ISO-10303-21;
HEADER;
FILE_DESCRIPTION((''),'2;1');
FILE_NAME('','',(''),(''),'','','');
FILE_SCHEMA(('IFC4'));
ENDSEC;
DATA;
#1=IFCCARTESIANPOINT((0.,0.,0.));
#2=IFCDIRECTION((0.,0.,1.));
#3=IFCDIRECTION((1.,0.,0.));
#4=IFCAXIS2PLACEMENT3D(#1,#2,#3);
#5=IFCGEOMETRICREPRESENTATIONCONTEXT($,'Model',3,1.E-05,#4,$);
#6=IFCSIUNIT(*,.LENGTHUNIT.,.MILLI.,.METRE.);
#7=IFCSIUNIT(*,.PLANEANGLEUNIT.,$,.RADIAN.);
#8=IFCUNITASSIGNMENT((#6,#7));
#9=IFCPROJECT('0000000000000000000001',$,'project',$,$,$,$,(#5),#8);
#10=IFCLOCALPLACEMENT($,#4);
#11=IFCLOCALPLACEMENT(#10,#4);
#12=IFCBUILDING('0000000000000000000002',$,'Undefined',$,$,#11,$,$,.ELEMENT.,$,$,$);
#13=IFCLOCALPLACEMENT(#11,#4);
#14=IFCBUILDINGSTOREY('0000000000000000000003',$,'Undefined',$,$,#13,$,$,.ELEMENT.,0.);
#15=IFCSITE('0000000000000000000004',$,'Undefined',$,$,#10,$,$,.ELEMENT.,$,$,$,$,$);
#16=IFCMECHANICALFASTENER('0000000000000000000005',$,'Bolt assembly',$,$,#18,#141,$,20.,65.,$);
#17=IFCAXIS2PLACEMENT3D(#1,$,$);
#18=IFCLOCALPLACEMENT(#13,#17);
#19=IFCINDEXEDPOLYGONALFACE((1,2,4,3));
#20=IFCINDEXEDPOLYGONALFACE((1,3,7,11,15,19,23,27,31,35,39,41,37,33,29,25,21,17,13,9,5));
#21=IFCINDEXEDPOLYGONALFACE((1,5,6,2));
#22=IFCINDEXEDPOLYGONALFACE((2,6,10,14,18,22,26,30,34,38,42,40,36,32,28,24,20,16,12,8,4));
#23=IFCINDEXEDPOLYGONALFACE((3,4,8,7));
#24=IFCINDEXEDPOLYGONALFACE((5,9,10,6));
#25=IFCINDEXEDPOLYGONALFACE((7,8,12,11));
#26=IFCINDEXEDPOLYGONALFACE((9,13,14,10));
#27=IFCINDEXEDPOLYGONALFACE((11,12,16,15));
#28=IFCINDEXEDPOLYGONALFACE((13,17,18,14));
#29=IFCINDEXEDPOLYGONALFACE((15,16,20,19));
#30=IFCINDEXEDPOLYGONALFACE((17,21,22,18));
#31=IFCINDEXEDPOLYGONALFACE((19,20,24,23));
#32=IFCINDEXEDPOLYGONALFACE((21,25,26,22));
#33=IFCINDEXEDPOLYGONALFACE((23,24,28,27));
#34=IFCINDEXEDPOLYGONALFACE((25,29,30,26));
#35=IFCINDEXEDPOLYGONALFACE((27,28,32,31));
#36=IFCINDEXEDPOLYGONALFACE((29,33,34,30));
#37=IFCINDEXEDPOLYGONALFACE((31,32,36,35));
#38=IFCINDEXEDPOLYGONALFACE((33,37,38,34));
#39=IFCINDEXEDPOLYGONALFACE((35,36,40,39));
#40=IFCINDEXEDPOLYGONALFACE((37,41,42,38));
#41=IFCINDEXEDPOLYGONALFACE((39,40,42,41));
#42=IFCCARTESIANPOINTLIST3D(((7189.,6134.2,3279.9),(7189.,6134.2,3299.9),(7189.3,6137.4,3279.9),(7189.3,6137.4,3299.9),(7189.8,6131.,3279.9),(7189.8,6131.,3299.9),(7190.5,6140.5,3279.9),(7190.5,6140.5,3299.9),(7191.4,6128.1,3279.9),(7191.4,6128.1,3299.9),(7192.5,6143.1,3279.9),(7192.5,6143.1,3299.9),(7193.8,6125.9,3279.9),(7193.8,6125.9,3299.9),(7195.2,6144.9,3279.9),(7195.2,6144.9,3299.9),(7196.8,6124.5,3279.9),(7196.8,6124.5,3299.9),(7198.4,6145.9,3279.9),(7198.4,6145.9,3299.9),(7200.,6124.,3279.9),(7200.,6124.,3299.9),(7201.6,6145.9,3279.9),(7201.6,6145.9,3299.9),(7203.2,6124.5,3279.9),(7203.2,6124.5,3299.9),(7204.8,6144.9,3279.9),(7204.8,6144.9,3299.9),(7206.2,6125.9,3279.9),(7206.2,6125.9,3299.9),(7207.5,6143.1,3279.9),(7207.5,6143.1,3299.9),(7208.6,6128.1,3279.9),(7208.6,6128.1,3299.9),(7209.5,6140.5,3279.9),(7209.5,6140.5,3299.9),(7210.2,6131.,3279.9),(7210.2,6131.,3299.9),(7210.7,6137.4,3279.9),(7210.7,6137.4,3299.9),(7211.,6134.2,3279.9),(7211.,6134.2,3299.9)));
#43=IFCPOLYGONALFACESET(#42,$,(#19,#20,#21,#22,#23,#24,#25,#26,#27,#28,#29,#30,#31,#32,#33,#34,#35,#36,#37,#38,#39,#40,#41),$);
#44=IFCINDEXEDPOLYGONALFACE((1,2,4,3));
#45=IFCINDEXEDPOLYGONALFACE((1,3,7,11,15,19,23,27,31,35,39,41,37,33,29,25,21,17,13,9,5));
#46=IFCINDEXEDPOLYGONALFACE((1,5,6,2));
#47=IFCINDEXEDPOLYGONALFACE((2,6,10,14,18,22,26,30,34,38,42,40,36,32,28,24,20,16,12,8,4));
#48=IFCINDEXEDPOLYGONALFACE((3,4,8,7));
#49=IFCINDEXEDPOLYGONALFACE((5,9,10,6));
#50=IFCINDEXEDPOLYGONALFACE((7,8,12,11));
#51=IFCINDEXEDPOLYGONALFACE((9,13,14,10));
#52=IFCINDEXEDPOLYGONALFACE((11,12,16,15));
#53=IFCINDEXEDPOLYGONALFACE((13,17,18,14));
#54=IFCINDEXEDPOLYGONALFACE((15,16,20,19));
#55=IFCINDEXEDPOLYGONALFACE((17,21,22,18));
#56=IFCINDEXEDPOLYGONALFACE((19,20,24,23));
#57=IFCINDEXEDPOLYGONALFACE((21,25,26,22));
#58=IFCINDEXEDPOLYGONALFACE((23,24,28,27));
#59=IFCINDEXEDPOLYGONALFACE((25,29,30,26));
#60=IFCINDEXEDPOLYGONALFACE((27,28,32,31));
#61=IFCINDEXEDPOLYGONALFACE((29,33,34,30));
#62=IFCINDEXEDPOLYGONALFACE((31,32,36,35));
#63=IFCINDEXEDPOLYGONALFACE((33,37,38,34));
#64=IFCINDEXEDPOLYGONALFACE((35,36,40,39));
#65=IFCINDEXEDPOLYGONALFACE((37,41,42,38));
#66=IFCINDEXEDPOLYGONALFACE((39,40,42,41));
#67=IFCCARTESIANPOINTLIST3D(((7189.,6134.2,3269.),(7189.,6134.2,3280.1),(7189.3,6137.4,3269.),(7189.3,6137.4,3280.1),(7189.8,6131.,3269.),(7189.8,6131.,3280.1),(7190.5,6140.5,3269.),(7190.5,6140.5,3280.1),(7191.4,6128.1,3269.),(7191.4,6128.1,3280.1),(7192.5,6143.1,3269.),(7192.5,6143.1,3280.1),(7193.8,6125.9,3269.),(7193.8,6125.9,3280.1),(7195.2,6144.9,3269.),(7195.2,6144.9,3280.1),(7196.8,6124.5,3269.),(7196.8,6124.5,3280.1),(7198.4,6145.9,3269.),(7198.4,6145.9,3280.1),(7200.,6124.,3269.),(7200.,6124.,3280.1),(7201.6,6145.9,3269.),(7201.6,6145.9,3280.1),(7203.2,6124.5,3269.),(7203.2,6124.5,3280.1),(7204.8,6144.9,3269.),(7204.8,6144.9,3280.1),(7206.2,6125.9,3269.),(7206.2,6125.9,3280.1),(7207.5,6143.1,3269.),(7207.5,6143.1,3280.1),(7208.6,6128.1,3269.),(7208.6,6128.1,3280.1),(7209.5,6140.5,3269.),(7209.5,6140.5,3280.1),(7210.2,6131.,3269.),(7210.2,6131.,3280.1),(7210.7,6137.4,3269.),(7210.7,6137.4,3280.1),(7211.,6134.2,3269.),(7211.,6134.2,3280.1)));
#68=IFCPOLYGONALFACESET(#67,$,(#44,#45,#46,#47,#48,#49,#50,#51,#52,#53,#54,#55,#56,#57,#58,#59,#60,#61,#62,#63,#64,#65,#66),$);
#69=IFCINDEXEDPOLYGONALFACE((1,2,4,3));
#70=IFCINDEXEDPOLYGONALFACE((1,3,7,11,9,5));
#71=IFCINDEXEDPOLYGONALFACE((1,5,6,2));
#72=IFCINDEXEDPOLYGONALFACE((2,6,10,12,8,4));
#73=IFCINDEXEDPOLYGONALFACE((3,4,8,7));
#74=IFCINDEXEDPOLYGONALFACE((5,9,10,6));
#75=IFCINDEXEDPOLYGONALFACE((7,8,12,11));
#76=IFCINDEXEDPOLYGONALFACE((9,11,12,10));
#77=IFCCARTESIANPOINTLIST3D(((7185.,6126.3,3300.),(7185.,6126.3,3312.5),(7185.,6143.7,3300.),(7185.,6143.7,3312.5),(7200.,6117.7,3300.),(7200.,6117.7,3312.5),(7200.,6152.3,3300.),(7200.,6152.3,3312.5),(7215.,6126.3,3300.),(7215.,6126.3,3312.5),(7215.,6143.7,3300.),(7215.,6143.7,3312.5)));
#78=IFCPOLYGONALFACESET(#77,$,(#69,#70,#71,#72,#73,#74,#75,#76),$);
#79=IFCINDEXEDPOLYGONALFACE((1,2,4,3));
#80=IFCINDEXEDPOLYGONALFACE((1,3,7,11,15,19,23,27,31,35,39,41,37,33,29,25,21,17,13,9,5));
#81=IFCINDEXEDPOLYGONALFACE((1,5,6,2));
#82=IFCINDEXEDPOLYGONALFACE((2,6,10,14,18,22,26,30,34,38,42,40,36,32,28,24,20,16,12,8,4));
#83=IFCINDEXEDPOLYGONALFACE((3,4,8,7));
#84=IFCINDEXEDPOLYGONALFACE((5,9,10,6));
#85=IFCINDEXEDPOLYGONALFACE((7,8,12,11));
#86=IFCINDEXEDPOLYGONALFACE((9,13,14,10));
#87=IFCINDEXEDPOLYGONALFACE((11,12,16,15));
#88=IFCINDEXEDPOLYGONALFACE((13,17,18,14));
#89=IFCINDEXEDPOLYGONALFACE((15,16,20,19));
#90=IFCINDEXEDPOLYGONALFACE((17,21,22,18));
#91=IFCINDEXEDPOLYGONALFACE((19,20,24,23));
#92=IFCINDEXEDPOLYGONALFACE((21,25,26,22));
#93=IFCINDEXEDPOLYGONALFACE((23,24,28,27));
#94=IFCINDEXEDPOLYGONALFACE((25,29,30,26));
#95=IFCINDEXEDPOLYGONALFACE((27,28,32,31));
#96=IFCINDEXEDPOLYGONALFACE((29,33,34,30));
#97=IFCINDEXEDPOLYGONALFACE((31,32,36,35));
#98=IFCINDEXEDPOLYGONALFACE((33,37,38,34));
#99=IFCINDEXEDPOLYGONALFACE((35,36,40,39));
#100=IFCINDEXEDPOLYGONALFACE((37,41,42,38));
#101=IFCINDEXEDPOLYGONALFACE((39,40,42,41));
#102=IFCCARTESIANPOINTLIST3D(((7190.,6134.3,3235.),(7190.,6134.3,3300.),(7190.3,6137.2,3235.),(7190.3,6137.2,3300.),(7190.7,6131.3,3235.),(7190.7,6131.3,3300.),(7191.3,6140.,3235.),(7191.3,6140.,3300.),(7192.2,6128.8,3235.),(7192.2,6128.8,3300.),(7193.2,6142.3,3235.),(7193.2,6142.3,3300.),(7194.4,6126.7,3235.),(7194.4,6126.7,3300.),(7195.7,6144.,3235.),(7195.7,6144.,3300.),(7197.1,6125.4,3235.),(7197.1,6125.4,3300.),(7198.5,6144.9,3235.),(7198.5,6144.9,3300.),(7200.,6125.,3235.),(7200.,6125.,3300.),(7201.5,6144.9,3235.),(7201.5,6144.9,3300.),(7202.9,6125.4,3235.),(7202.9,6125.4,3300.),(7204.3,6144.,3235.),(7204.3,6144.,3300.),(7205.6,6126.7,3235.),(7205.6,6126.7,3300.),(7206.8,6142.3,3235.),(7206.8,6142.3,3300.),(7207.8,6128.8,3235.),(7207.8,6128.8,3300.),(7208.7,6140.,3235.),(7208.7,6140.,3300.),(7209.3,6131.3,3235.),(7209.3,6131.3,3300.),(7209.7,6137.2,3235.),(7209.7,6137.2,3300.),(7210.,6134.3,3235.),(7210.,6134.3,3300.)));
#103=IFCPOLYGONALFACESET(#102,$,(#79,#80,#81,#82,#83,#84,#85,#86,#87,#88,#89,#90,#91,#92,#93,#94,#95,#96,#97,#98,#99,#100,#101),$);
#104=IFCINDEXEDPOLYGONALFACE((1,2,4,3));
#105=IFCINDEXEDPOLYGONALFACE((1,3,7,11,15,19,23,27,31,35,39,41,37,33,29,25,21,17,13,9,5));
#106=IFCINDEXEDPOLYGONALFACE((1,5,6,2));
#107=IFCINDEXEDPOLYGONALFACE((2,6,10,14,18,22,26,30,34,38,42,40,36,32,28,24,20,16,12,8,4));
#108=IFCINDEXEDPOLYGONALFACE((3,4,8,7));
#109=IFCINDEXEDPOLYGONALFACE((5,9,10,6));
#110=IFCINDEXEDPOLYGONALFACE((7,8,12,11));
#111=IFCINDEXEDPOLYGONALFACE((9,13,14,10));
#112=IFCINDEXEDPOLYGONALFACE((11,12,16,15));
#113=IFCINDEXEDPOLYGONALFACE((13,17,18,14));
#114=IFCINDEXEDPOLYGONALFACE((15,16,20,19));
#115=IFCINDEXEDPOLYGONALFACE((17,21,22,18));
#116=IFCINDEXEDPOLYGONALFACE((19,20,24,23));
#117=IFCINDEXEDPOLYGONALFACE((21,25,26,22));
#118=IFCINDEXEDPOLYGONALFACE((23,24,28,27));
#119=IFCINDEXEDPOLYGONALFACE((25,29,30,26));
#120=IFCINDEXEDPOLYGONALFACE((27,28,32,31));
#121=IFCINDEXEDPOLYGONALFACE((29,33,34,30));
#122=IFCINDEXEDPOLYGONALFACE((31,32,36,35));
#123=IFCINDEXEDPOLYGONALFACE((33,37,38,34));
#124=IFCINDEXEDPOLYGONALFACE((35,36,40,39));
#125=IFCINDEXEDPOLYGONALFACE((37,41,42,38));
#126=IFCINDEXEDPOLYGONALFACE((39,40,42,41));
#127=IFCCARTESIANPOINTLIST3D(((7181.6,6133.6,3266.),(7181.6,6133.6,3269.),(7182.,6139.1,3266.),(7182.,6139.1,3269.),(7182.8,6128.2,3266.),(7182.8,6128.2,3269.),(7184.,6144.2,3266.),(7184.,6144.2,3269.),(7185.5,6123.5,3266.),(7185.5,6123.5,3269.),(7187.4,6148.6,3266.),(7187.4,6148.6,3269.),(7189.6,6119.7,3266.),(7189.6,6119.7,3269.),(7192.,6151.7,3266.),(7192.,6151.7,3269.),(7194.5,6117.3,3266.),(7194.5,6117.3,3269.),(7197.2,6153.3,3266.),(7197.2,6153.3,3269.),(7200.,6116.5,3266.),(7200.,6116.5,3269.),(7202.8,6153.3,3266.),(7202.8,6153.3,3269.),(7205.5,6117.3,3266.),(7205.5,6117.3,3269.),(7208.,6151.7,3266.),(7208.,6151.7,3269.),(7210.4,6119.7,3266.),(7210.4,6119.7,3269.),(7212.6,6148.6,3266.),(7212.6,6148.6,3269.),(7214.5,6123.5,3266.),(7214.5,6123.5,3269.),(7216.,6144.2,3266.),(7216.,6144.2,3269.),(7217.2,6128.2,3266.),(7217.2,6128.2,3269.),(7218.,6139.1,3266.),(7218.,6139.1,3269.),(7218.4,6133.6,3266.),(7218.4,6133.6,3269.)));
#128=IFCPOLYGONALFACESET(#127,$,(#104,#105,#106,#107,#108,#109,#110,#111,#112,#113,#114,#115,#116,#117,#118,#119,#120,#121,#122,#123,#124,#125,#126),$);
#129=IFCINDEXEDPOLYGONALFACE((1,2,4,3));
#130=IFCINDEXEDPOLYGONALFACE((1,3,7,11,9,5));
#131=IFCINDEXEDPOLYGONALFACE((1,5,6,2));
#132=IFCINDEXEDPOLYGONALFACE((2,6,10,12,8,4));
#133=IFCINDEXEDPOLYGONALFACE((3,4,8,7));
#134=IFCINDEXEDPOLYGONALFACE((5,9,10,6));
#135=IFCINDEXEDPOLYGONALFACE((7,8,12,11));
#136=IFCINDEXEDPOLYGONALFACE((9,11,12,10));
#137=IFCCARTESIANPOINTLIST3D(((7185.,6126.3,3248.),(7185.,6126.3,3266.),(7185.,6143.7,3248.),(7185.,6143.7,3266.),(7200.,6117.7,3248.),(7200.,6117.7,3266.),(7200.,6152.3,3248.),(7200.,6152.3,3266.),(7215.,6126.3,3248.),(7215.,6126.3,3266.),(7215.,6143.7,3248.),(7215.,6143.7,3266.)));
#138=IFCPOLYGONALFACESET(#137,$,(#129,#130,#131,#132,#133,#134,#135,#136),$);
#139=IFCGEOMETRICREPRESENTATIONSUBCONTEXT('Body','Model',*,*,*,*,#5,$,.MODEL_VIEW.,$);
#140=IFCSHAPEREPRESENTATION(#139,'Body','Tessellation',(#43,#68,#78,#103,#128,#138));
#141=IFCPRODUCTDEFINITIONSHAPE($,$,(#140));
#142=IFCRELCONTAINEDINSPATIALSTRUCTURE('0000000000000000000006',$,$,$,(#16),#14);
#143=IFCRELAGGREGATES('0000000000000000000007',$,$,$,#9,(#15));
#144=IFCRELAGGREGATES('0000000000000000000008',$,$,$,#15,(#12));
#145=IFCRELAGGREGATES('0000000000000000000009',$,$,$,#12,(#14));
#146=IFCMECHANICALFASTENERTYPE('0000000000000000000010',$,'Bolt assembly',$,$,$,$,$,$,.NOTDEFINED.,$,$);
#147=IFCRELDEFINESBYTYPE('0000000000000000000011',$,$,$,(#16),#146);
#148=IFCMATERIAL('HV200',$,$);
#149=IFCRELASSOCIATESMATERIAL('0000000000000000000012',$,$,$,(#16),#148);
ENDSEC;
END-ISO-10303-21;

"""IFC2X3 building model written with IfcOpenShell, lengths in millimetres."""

from ifc_helpers import new_model, si_unit, frame, origin_with_axes, origin_2d_with_axis, place, context, subcontext, project, spatial, polyline, circle, outline, extrude, source, transform, mapped, material, type_object, element, save


model = new_model("IFC2X3")

# Units and contexts
model_context = context("Model", 3, precision=1e-05, world=origin_with_axes())
body_context = subcontext(model_context, "Body", "Model", "MODEL_VIEW")
ifc_project = project(units=[si_unit("LENGTHUNIT", "METRE", prefix="MILLI"), si_unit("PLANEANGLEUNIT", "RADIAN")], contexts=[model_context])

# Site, building, storey
site_placement = place(None, origin_with_axes())
site = spatial("IfcSite", under=ifc_project, at=site_placement, Name="Undefined", CompositionType="ELEMENT")
building_placement = place(site_placement, origin_with_axes())
building = spatial("IfcBuilding", under=site, at=building_placement, Name="Undefined", CompositionType="ELEMENT")
storey_placement = place(building_placement, origin_with_axes())
storey = spatial("IfcBuildingStorey", under=building, at=storey_placement, Name="Undefined", CompositionType="ELEMENT", Elevation=0.0)

# Mechanical fastener
ifc_material_1 = material(Name="HV200")
mechanical_fastener_type = type_object("IfcMechanicalFastenerType", Name="Bolt assembly")
shared_shape_1 = source(origin_with_axes(), body_context, "Body", "SweptSolid", [
    extrude(circle(Radius=11.0, at=origin_2d_with_axis()), frame((0.0, -19.9, 0.0), z_axis=(0.0, 1.0, 0.0), x_axis=(1.0, 0.0, 0.0)), (0.0, 0.0, 1.0), 20.0),
    extrude(circle(Radius=11.0, at=origin_2d_with_axis()), frame((0.0, -0.1, 0.0), z_axis=(0.0, 1.0, 0.0), x_axis=(1.0, 0.0, 0.0)), (0.0, 0.0, 1.0), 11.1),
    extrude(outline(polyline([(17.3, 0.0), (8.7, 15.0), (-8.7, 15.0), (-17.3, 0.0), (-8.7, -15.0), (8.7, -15.0), (17.3, 0.0)])), frame((0.0, -32.5, 0.0), z_axis=(0.0, 1.0, 0.0), x_axis=(1.0, 0.0, 0.0)), (0.0, 0.0, 1.0), 12.5),
    extrude(circle(Radius=10.0, at=origin_2d_with_axis()), frame((0.0, -20.0, 0.0), z_axis=(0.0, 1.0, 0.0), x_axis=(1.0, 0.0, 0.0)), (0.0, 0.0, 1.0), 65.0),
    extrude(circle(Radius=18.5, at=origin_2d_with_axis()), frame((0.0, 11.0, 0.0), z_axis=(0.0, 1.0, 0.0), x_axis=(1.0, 0.0, 0.0)), (0.0, 0.0, 1.0), 3.0),
    extrude(outline(polyline([(17.3, 0.0), (8.7, 15.0), (-8.7, 15.0), (-17.3, 0.0), (-8.7, -15.0), (8.7, -15.0), (17.3, 0.0)])), frame((0.0, 14.0, 0.0), z_axis=(0.0, 1.0, 0.0), x_axis=(1.0, 0.0, 0.0)), (0.0, 0.0, 1.0), 18.0),
])
for number, where, z_axis, x_axis, name in (
    (1, (7200.0, 6135.0, 3280.0), (1.0, 0.0, 0.0), (0.0, -1.0, 0.0), "Bolt assembly"),
):
    element("IfcMechanicalFastener", number, at=place(storey_placement, frame(where, z_axis=z_axis, x_axis=x_axis)), inside=storey, type_object=mechanical_fastener_type, material=ifc_material_1, Name=name, NominalDiameter=20.0, NominalLength=65.0, context=body_context, shape_type="MappedRepresentation", body=[
        mapped(shared_shape_1, transform((0.0, 0.0, 0.0))),
    ])

save(model, "model.ifc")
